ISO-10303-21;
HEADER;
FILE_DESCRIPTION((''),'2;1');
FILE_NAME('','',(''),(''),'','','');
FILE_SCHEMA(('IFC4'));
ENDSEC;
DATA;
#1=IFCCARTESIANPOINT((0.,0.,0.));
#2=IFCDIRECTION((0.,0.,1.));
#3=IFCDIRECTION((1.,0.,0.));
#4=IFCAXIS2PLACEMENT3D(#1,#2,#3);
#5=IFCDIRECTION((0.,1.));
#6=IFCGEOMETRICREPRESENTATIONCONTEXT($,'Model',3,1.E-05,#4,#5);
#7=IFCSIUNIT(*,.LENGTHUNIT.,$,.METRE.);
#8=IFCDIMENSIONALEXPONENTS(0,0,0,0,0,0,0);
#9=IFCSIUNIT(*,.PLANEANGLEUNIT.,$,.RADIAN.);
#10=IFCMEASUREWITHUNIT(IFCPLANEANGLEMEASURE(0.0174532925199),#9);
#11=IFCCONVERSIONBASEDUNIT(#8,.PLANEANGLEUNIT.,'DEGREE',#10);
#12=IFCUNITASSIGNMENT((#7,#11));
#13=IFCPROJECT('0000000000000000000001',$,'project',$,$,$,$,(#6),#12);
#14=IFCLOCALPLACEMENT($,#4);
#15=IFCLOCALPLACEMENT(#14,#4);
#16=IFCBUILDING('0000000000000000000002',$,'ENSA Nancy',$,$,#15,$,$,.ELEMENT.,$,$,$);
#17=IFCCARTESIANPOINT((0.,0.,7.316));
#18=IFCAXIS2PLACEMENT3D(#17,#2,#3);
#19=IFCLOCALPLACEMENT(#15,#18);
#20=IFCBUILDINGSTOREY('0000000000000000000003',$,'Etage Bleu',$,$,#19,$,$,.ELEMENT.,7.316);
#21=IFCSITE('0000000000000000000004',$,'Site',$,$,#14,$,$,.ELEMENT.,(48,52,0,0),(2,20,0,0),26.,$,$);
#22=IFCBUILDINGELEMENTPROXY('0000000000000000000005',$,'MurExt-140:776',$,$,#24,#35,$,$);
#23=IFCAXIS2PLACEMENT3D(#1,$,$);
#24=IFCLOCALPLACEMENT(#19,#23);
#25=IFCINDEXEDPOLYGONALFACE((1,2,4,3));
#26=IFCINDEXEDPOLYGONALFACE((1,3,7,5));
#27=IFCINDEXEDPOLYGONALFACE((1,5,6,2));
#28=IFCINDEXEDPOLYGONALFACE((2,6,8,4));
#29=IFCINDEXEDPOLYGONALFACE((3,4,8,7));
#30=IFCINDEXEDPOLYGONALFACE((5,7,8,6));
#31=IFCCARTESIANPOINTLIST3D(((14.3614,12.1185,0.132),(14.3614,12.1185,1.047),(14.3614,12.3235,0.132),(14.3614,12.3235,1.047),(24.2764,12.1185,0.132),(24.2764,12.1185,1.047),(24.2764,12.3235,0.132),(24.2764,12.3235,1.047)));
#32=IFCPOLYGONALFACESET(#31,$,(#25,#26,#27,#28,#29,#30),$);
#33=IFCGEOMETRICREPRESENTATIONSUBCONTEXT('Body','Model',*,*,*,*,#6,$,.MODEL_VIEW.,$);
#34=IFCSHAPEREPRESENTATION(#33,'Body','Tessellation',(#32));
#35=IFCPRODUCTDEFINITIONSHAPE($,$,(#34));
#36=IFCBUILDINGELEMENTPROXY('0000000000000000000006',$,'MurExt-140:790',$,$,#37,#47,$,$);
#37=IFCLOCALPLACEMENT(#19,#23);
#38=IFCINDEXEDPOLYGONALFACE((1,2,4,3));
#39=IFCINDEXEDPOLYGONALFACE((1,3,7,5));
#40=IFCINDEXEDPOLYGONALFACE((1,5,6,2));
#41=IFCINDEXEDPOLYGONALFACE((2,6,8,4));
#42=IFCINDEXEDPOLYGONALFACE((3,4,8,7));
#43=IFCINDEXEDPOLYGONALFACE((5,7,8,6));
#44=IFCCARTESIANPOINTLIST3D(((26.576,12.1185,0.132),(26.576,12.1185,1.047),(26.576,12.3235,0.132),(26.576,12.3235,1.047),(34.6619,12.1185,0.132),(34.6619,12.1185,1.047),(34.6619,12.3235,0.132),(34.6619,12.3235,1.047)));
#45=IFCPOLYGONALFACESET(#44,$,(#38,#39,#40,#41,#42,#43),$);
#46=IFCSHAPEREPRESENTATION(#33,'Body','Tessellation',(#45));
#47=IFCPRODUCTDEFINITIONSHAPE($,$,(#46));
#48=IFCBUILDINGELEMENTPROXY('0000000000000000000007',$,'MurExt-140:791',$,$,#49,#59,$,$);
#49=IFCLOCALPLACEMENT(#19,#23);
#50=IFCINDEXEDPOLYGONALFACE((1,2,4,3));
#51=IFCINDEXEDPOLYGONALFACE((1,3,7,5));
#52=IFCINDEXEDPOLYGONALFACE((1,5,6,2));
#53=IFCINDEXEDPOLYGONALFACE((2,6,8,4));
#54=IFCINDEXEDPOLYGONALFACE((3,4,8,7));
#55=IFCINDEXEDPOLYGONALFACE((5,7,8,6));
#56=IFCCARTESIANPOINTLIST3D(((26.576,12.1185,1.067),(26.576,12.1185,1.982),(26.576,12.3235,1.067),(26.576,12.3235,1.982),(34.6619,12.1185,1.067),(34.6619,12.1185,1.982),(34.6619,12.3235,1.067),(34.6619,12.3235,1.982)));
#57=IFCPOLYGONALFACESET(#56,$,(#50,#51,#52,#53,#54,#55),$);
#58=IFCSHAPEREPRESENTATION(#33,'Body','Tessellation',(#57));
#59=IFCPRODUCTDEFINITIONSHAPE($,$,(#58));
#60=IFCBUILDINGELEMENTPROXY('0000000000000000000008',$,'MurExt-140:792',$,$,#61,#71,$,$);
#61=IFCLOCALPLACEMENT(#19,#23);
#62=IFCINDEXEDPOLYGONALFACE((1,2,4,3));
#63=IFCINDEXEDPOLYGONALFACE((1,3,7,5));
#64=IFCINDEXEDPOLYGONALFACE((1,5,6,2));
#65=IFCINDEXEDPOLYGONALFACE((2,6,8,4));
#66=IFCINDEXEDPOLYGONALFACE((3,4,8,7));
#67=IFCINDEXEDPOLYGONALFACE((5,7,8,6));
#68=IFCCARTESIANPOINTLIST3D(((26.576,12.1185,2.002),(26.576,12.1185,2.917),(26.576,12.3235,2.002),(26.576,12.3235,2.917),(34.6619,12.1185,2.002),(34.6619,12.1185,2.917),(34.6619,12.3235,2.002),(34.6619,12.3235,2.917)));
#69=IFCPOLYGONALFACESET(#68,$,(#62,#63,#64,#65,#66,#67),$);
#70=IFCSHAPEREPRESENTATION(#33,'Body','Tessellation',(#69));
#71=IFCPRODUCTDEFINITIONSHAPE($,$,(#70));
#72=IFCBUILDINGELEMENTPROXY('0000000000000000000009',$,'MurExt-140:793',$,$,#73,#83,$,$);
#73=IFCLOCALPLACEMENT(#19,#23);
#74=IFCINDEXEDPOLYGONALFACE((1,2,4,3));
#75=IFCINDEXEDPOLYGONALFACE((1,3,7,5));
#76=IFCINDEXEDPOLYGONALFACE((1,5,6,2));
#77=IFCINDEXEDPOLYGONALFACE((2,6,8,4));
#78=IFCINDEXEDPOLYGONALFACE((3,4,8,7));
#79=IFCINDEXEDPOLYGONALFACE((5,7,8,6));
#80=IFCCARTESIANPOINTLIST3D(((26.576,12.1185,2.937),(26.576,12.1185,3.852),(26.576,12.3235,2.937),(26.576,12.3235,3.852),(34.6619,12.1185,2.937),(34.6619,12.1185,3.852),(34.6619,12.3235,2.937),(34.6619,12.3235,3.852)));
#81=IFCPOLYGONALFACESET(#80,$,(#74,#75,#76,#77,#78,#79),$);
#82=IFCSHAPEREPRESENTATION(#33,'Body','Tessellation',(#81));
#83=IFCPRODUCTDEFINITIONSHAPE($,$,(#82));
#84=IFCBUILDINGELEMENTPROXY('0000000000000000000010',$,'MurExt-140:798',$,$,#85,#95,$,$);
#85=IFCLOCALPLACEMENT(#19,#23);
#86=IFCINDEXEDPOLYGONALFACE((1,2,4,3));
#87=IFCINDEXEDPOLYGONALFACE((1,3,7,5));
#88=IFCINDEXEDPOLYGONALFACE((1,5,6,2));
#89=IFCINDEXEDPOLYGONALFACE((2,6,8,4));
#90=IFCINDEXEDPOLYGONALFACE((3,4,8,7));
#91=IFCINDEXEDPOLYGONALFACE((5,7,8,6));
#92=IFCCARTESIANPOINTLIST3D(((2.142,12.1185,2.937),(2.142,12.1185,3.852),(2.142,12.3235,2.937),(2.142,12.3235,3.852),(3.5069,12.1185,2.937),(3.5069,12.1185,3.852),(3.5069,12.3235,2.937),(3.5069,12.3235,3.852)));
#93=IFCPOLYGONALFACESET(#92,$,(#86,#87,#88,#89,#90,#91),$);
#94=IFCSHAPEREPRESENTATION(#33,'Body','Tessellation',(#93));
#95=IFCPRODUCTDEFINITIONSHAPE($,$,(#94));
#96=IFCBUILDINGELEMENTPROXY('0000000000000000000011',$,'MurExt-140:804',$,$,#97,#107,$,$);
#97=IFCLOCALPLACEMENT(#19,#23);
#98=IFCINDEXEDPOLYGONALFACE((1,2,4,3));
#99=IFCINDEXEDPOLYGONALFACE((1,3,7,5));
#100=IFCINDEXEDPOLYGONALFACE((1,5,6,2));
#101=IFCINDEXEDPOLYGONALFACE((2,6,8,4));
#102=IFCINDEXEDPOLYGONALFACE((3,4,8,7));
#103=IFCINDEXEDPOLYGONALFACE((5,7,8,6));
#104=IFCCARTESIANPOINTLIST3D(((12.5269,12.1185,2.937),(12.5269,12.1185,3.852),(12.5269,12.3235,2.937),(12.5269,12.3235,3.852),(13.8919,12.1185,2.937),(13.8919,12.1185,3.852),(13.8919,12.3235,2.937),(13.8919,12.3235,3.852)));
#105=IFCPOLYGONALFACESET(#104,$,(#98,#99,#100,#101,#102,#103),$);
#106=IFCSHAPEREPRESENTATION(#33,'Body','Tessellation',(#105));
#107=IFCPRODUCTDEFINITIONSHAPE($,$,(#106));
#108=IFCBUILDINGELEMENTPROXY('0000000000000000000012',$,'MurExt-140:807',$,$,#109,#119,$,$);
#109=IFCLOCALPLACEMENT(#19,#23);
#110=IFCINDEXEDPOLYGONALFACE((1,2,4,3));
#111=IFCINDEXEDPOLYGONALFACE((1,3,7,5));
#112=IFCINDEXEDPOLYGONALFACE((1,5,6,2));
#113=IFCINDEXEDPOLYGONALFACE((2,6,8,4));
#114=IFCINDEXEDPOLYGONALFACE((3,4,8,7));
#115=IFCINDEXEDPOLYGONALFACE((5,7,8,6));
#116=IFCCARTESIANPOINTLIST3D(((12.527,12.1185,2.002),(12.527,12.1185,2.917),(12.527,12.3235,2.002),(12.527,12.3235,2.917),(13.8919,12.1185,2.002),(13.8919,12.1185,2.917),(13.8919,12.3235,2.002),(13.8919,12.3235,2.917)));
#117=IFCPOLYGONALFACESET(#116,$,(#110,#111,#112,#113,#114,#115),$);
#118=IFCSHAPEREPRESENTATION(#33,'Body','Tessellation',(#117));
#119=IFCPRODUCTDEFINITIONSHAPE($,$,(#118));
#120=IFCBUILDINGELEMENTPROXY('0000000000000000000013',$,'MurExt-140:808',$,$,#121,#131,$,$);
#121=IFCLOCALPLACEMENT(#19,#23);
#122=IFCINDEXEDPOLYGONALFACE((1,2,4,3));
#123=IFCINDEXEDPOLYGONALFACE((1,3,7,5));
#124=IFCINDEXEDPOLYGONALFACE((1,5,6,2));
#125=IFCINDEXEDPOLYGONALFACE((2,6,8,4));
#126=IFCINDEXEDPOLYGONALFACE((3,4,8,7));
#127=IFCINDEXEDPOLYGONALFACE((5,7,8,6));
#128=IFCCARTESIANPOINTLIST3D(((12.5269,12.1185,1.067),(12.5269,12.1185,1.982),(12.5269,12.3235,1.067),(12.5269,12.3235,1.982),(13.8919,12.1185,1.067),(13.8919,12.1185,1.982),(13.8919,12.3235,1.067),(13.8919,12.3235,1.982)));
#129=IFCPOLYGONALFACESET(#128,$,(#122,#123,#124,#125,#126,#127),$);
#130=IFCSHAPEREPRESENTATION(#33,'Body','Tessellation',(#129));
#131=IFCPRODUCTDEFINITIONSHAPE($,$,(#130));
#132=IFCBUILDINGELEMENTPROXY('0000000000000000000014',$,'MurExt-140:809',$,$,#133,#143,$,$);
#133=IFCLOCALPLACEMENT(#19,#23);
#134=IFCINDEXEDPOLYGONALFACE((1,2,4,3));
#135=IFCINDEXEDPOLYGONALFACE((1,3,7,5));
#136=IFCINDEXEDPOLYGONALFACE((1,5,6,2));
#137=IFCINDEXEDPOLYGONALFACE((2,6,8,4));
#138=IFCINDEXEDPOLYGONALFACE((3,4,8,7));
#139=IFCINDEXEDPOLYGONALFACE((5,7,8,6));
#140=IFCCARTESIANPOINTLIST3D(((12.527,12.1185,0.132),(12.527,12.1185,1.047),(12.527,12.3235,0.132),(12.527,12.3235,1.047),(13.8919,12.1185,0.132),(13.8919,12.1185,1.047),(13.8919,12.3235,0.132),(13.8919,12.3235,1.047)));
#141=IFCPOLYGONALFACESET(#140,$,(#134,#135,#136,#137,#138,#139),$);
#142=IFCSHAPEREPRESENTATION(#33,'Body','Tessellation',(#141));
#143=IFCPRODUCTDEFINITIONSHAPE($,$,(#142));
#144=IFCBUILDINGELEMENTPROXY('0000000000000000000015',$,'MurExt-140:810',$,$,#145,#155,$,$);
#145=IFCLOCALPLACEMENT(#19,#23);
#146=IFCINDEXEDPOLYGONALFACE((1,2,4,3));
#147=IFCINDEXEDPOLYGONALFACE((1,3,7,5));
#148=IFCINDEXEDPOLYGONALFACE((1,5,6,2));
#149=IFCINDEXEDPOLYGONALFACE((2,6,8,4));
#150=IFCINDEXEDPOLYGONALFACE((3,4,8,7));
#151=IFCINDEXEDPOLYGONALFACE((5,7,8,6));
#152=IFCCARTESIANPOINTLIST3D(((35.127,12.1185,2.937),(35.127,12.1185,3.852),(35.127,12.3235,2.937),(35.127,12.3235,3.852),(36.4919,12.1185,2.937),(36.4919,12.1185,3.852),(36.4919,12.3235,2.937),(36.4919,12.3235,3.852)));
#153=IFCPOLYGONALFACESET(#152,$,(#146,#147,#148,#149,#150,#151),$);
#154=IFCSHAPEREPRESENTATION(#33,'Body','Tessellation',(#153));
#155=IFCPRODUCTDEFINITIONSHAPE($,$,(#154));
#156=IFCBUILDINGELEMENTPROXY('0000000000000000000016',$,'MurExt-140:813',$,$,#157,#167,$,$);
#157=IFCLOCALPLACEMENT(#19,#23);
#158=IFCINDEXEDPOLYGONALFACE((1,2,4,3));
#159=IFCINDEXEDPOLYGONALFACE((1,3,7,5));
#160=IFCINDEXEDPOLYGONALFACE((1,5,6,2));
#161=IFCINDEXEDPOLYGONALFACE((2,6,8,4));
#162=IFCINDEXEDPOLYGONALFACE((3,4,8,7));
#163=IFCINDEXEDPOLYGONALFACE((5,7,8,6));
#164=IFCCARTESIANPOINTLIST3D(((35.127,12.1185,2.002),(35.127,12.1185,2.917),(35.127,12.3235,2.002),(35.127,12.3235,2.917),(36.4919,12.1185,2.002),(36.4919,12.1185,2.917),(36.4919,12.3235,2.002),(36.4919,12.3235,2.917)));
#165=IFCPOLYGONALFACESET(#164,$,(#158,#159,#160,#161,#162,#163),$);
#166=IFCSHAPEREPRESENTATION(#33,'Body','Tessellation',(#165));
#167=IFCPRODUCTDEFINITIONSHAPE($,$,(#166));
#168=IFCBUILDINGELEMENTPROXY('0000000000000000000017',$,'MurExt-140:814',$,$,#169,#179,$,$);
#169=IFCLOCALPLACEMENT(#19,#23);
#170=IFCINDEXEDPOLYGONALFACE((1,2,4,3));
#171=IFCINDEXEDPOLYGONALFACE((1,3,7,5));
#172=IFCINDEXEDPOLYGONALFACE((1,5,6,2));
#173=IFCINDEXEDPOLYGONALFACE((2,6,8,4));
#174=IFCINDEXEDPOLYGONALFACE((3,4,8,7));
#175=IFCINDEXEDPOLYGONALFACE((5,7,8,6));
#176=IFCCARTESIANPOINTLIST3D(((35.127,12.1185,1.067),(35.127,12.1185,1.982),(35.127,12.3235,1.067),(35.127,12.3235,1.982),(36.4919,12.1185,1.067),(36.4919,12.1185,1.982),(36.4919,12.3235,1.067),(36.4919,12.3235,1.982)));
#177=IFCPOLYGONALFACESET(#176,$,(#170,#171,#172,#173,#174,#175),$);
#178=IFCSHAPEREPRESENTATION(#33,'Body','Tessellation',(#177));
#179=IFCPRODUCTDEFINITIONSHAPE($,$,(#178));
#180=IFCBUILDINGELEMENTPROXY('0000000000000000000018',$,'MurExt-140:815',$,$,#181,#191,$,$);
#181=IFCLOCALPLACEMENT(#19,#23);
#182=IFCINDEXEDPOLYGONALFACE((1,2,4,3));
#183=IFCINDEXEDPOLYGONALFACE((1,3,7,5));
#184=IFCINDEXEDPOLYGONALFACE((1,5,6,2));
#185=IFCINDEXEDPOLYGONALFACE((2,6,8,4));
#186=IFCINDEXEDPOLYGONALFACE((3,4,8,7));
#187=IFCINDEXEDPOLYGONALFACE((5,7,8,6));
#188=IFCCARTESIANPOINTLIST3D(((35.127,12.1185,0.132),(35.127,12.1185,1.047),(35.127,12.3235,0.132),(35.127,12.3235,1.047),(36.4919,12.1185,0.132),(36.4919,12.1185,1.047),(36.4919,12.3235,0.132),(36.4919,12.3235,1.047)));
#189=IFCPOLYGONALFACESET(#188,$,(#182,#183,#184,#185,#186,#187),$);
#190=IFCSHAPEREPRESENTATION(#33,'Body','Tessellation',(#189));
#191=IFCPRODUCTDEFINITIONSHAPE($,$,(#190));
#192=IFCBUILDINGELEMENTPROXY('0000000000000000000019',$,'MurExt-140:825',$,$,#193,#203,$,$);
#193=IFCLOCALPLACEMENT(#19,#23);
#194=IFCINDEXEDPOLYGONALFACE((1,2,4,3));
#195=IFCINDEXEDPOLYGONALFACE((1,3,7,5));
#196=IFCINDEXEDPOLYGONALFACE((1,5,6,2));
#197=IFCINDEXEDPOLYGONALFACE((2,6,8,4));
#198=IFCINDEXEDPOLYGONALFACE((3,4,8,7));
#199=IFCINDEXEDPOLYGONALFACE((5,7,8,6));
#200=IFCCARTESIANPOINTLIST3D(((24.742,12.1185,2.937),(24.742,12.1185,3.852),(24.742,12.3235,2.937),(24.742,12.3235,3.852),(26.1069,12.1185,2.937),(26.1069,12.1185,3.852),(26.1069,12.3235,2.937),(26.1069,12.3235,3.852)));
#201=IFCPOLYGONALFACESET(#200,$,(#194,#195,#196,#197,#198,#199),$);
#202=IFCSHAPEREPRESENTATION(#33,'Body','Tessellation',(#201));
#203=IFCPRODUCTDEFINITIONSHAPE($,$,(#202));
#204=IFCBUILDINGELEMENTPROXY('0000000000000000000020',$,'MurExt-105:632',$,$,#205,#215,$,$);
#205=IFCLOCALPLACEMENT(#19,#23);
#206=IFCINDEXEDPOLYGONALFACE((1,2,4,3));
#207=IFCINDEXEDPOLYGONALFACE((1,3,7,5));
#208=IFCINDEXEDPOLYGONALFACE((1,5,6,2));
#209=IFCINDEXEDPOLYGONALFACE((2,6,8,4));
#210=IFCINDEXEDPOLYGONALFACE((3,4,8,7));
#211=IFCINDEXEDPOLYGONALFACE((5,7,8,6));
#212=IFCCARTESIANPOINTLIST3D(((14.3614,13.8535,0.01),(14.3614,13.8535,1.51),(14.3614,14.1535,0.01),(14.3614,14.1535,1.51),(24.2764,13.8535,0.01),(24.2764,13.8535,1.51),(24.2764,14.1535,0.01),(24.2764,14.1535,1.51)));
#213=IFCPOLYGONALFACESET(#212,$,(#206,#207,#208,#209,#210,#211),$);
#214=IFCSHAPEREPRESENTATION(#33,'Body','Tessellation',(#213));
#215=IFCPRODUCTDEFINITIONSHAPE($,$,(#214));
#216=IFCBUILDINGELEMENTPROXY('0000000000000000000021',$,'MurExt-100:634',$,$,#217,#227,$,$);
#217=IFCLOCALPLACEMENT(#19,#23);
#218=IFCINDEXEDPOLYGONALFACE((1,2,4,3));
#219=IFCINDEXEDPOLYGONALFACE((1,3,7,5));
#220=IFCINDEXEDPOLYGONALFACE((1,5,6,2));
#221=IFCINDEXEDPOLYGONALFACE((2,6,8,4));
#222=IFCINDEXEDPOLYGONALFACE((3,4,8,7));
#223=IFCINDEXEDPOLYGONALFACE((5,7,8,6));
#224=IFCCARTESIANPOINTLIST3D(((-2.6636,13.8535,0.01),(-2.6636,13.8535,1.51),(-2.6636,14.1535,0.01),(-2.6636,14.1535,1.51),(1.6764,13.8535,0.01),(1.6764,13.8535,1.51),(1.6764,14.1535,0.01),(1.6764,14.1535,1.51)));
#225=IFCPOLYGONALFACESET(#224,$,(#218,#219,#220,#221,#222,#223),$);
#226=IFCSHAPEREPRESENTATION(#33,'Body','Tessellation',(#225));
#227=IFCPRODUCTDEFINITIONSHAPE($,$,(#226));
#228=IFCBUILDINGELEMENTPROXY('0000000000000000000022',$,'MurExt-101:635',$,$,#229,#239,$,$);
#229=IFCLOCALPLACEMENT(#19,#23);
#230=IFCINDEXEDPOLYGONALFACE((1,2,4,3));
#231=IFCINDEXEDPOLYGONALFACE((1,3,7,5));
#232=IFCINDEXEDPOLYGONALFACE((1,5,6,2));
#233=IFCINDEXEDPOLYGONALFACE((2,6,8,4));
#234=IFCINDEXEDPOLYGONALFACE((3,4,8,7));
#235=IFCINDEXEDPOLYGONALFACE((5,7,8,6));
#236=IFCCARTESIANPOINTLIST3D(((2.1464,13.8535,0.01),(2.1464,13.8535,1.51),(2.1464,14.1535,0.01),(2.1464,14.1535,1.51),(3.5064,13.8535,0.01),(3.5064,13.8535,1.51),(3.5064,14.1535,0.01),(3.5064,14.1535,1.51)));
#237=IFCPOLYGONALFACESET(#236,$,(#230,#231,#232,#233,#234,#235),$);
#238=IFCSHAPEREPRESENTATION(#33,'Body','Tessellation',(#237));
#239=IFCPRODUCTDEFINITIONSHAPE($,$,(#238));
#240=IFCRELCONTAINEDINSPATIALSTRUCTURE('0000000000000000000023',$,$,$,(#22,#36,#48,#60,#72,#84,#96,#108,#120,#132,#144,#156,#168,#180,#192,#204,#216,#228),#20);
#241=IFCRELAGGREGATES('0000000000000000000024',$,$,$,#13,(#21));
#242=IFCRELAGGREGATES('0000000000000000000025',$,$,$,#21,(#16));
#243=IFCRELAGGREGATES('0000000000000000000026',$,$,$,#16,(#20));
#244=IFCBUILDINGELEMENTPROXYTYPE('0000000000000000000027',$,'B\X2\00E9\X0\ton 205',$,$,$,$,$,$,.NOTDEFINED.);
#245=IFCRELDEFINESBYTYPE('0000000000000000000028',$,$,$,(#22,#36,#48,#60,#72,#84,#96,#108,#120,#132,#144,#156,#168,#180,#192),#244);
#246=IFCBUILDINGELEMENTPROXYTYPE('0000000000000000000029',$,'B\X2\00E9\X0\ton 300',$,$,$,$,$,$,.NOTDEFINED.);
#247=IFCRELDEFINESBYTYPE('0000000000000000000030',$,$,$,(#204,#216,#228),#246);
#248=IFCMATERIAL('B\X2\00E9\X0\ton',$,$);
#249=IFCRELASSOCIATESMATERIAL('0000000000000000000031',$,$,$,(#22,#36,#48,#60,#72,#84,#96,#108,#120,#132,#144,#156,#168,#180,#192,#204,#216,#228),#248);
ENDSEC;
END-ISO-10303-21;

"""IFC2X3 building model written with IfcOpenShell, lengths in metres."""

from ifc_helpers import new_model, entity, si_unit, converted_unit, direction, frame, origin_with_axes, place, context, subcontext, project, spatial, polyline, outline, extrude, material, type_object, element, save


model = new_model("IFC2X3")

# Units and contexts
model_context = context("Model", 3, precision=1e-05, world=origin_with_axes(), true_north=direction((0.0, 1.0)))
body_context = subcontext(model_context, "Body", "Model", "MODEL_VIEW")
ifc_project = project(units=[si_unit("LENGTHUNIT", "METRE"), converted_unit("PLANEANGLEUNIT", "DEGREE", entity("IfcPlaneAngleMeasure", 0.0174532925199), si_unit("PLANEANGLEUNIT", "RADIAN"), dimensions=[0, 0, 0, 0, 0, 0, 0])], contexts=[model_context])

# Site, building, storey
site_placement = place(None, origin_with_axes())
site = spatial("IfcSite", under=ifc_project, at=site_placement, Name="Site", CompositionType="ELEMENT", RefLatitude=(48, 52, 0, 0), RefLongitude=(2, 20, 0, 0), RefElevation=26.0)
building_placement = place(site_placement, origin_with_axes())
building = spatial("IfcBuilding", under=site, at=building_placement, Name="ENSA Nancy", CompositionType="ELEMENT")
storey_placement = place(building_placement, frame((0.0, 0.0, 7.316), z_axis=(0.0, 0.0, 1.0), x_axis=(1.0, 0.0, 0.0)))
storey = spatial("IfcBuildingStorey", under=building, at=storey_placement, Name="Etage Bleu", CompositionType="ELEMENT", Elevation=7.316)

# Building element proxies
ifc_material = material(Name="Béton")
building_element_proxy_type_1 = type_object("IfcBuildingElementProxyType", Name="Béton 205", PredefinedType="NOTDEFINED")
proxy_1_placement = place(storey_placement, frame((14.3614, 12.3235, 0.132), z_axis=(0.0, 0.0, 1.0), x_axis=(1.0, 0.0, 0.0)))
element("IfcBuildingElementProxy", 1, at=proxy_1_placement, inside=storey, type_object=building_element_proxy_type_1, material=ifc_material, Name="MurExt-140:776", context=body_context, shape_type="SweptSolid", body=[
    extrude(outline(polyline([(0.0, -0.205), (9.915, -0.205), (9.915, 0.0), (0.0, 0.0), (0.0, -0.205)])), origin_with_axes(), (0.0, 0.0, 1.0), 0.915),
])
for number, where, z_axis, x_axis, name in (
    (2, (26.576, 12.3235, 0.132), (0.0, 0.0, 1.0), (1.0, 0.0, 0.0), "MurExt-140:790"),
    (3, (26.576, 12.3235, 1.067), (0.0, 0.0, 1.0), (1.0, 0.0, 0.0), "MurExt-140:791"),
    (4, (26.576, 12.3235, 2.002), (0.0, 0.0, 1.0), (1.0, 0.0, 0.0), "MurExt-140:792"),
    (5, (26.576, 12.3235, 2.937), (0.0, 0.0, 1.0), (1.0, 0.0, 0.0), "MurExt-140:793"),
):
    element("IfcBuildingElementProxy", number, at=place(storey_placement, frame(where, z_axis=z_axis, x_axis=x_axis)), inside=storey, type_object=building_element_proxy_type_1, material=ifc_material, Name=name, context=body_context, shape_type="SweptSolid", body=[
        extrude(outline(polyline([(0.0, -0.205), (8.0859, -0.205), (8.0859, 0.0), (0.0, 0.0), (0.0, -0.205)])), origin_with_axes(), (0.0, 0.0, 1.0), 0.915),
    ])
for number, where, z_axis, x_axis, name in (
    (6, (2.142, 12.3235, 2.937), (0.0, 0.0, 1.0), (1.0, -0.000005, 0.0), "MurExt-140:798"),
    (7, (12.5269, 12.3235, 2.937), (0.0, 0.0, 1.0), (1.0, -0.000005, 0.0), "MurExt-140:804"),
    (8, (12.527, 12.3235, 2.002), (0.0, 0.0, 1.0), (1.0, -0.000005, 0.0), "MurExt-140:807"),
    (9, (12.5269, 12.3235, 1.067), (0.0, 0.0, 1.0), (1.0, -0.000005, 0.0), "MurExt-140:808"),
    (10, (12.527, 12.3235, 0.132), (0.0, 0.0, 1.0), (1.0, -0.000005, 0.0), "MurExt-140:809"),
    (11, (35.127, 12.3235, 2.937), (0.0, 0.0, 1.0), (1.0, -0.000005, 0.0), "MurExt-140:810"),
    (12, (35.127, 12.3235, 2.002), (0.0, 0.0, 1.0), (1.0, -0.000005, 0.0), "MurExt-140:813"),
    (13, (35.127, 12.3235, 1.067), (0.0, 0.0, 1.0), (1.0, -0.000005, 0.0), "MurExt-140:814"),
    (14, (35.127, 12.3235, 0.132), (0.0, 0.0, 1.0), (1.0, -0.000005, 0.0), "MurExt-140:815"),
    (15, (24.742, 12.3235, 2.937), (0.0, 0.0, 1.0), (1.0, -0.000005, 0.0), "MurExt-140:825"),
):
    element("IfcBuildingElementProxy", number, at=place(storey_placement, frame(where, z_axis=z_axis, x_axis=x_axis)), inside=storey, type_object=building_element_proxy_type_1, material=ifc_material, Name=name, context=body_context, shape_type="SweptSolid", body=[
        extrude(outline(polyline([(0.0, -0.205), (1.3649, -0.205), (1.3649, 0.0), (0.0, 0.0), (0.0, -0.205)])), origin_with_axes(), (0.0, 0.0, 1.0), 0.915),
    ])
building_element_proxy_type_2 = type_object("IfcBuildingElementProxyType", Name="Béton 300", PredefinedType="NOTDEFINED")
proxy_2_placement = place(storey_placement, frame((14.3614, 13.8535, 0.01), z_axis=(0.0, 0.0, 1.0), x_axis=(1.0, 0.0, 0.0)))
element("IfcBuildingElementProxy", 16, at=proxy_2_placement, inside=storey, type_object=building_element_proxy_type_2, material=ifc_material, Name="MurExt-105:632", context=body_context, shape_type="SweptSolid", body=[
    extrude(outline(polyline([(0.0, 0.0), (9.915, 0.0), (9.915, 0.3), (0.0, 0.3), (0.0, 0.0)])), origin_with_axes(), (0.0, 0.0, 1.0), 1.5),
])
proxy_3_placement = place(storey_placement, frame((-2.6636, 13.8535, 0.01), z_axis=(0.0, 0.0, 1.0), x_axis=(1.0, 0.0, 0.0)))
element("IfcBuildingElementProxy", 17, at=proxy_3_placement, inside=storey, type_object=building_element_proxy_type_2, material=ifc_material, Name="MurExt-100:634", context=body_context, shape_type="SweptSolid", body=[
    extrude(outline(polyline([(0.0, 0.0), (4.34, 0.0), (4.34, 0.3), (0.0, 0.3), (0.0, 0.0)])), origin_with_axes(), (0.0, 0.0, 1.0), 1.5),
])
proxy_4_placement = place(storey_placement, frame((2.1464, 13.8535, 0.01), z_axis=(0.0, 0.0, 1.0), x_axis=(1.0, 0.0, 0.0)))
element("IfcBuildingElementProxy", 18, at=proxy_4_placement, inside=storey, type_object=building_element_proxy_type_2, material=ifc_material, Name="MurExt-101:635", context=body_context, shape_type="SweptSolid", body=[
    extrude(outline(polyline([(0.0, 0.0), (1.36, 0.0), (1.36, 0.3), (0.0, 0.3), (0.0, 0.0)])), origin_with_axes(), (0.0, 0.0, 1.0), 1.5),
])

save(model, "model.ifc")
